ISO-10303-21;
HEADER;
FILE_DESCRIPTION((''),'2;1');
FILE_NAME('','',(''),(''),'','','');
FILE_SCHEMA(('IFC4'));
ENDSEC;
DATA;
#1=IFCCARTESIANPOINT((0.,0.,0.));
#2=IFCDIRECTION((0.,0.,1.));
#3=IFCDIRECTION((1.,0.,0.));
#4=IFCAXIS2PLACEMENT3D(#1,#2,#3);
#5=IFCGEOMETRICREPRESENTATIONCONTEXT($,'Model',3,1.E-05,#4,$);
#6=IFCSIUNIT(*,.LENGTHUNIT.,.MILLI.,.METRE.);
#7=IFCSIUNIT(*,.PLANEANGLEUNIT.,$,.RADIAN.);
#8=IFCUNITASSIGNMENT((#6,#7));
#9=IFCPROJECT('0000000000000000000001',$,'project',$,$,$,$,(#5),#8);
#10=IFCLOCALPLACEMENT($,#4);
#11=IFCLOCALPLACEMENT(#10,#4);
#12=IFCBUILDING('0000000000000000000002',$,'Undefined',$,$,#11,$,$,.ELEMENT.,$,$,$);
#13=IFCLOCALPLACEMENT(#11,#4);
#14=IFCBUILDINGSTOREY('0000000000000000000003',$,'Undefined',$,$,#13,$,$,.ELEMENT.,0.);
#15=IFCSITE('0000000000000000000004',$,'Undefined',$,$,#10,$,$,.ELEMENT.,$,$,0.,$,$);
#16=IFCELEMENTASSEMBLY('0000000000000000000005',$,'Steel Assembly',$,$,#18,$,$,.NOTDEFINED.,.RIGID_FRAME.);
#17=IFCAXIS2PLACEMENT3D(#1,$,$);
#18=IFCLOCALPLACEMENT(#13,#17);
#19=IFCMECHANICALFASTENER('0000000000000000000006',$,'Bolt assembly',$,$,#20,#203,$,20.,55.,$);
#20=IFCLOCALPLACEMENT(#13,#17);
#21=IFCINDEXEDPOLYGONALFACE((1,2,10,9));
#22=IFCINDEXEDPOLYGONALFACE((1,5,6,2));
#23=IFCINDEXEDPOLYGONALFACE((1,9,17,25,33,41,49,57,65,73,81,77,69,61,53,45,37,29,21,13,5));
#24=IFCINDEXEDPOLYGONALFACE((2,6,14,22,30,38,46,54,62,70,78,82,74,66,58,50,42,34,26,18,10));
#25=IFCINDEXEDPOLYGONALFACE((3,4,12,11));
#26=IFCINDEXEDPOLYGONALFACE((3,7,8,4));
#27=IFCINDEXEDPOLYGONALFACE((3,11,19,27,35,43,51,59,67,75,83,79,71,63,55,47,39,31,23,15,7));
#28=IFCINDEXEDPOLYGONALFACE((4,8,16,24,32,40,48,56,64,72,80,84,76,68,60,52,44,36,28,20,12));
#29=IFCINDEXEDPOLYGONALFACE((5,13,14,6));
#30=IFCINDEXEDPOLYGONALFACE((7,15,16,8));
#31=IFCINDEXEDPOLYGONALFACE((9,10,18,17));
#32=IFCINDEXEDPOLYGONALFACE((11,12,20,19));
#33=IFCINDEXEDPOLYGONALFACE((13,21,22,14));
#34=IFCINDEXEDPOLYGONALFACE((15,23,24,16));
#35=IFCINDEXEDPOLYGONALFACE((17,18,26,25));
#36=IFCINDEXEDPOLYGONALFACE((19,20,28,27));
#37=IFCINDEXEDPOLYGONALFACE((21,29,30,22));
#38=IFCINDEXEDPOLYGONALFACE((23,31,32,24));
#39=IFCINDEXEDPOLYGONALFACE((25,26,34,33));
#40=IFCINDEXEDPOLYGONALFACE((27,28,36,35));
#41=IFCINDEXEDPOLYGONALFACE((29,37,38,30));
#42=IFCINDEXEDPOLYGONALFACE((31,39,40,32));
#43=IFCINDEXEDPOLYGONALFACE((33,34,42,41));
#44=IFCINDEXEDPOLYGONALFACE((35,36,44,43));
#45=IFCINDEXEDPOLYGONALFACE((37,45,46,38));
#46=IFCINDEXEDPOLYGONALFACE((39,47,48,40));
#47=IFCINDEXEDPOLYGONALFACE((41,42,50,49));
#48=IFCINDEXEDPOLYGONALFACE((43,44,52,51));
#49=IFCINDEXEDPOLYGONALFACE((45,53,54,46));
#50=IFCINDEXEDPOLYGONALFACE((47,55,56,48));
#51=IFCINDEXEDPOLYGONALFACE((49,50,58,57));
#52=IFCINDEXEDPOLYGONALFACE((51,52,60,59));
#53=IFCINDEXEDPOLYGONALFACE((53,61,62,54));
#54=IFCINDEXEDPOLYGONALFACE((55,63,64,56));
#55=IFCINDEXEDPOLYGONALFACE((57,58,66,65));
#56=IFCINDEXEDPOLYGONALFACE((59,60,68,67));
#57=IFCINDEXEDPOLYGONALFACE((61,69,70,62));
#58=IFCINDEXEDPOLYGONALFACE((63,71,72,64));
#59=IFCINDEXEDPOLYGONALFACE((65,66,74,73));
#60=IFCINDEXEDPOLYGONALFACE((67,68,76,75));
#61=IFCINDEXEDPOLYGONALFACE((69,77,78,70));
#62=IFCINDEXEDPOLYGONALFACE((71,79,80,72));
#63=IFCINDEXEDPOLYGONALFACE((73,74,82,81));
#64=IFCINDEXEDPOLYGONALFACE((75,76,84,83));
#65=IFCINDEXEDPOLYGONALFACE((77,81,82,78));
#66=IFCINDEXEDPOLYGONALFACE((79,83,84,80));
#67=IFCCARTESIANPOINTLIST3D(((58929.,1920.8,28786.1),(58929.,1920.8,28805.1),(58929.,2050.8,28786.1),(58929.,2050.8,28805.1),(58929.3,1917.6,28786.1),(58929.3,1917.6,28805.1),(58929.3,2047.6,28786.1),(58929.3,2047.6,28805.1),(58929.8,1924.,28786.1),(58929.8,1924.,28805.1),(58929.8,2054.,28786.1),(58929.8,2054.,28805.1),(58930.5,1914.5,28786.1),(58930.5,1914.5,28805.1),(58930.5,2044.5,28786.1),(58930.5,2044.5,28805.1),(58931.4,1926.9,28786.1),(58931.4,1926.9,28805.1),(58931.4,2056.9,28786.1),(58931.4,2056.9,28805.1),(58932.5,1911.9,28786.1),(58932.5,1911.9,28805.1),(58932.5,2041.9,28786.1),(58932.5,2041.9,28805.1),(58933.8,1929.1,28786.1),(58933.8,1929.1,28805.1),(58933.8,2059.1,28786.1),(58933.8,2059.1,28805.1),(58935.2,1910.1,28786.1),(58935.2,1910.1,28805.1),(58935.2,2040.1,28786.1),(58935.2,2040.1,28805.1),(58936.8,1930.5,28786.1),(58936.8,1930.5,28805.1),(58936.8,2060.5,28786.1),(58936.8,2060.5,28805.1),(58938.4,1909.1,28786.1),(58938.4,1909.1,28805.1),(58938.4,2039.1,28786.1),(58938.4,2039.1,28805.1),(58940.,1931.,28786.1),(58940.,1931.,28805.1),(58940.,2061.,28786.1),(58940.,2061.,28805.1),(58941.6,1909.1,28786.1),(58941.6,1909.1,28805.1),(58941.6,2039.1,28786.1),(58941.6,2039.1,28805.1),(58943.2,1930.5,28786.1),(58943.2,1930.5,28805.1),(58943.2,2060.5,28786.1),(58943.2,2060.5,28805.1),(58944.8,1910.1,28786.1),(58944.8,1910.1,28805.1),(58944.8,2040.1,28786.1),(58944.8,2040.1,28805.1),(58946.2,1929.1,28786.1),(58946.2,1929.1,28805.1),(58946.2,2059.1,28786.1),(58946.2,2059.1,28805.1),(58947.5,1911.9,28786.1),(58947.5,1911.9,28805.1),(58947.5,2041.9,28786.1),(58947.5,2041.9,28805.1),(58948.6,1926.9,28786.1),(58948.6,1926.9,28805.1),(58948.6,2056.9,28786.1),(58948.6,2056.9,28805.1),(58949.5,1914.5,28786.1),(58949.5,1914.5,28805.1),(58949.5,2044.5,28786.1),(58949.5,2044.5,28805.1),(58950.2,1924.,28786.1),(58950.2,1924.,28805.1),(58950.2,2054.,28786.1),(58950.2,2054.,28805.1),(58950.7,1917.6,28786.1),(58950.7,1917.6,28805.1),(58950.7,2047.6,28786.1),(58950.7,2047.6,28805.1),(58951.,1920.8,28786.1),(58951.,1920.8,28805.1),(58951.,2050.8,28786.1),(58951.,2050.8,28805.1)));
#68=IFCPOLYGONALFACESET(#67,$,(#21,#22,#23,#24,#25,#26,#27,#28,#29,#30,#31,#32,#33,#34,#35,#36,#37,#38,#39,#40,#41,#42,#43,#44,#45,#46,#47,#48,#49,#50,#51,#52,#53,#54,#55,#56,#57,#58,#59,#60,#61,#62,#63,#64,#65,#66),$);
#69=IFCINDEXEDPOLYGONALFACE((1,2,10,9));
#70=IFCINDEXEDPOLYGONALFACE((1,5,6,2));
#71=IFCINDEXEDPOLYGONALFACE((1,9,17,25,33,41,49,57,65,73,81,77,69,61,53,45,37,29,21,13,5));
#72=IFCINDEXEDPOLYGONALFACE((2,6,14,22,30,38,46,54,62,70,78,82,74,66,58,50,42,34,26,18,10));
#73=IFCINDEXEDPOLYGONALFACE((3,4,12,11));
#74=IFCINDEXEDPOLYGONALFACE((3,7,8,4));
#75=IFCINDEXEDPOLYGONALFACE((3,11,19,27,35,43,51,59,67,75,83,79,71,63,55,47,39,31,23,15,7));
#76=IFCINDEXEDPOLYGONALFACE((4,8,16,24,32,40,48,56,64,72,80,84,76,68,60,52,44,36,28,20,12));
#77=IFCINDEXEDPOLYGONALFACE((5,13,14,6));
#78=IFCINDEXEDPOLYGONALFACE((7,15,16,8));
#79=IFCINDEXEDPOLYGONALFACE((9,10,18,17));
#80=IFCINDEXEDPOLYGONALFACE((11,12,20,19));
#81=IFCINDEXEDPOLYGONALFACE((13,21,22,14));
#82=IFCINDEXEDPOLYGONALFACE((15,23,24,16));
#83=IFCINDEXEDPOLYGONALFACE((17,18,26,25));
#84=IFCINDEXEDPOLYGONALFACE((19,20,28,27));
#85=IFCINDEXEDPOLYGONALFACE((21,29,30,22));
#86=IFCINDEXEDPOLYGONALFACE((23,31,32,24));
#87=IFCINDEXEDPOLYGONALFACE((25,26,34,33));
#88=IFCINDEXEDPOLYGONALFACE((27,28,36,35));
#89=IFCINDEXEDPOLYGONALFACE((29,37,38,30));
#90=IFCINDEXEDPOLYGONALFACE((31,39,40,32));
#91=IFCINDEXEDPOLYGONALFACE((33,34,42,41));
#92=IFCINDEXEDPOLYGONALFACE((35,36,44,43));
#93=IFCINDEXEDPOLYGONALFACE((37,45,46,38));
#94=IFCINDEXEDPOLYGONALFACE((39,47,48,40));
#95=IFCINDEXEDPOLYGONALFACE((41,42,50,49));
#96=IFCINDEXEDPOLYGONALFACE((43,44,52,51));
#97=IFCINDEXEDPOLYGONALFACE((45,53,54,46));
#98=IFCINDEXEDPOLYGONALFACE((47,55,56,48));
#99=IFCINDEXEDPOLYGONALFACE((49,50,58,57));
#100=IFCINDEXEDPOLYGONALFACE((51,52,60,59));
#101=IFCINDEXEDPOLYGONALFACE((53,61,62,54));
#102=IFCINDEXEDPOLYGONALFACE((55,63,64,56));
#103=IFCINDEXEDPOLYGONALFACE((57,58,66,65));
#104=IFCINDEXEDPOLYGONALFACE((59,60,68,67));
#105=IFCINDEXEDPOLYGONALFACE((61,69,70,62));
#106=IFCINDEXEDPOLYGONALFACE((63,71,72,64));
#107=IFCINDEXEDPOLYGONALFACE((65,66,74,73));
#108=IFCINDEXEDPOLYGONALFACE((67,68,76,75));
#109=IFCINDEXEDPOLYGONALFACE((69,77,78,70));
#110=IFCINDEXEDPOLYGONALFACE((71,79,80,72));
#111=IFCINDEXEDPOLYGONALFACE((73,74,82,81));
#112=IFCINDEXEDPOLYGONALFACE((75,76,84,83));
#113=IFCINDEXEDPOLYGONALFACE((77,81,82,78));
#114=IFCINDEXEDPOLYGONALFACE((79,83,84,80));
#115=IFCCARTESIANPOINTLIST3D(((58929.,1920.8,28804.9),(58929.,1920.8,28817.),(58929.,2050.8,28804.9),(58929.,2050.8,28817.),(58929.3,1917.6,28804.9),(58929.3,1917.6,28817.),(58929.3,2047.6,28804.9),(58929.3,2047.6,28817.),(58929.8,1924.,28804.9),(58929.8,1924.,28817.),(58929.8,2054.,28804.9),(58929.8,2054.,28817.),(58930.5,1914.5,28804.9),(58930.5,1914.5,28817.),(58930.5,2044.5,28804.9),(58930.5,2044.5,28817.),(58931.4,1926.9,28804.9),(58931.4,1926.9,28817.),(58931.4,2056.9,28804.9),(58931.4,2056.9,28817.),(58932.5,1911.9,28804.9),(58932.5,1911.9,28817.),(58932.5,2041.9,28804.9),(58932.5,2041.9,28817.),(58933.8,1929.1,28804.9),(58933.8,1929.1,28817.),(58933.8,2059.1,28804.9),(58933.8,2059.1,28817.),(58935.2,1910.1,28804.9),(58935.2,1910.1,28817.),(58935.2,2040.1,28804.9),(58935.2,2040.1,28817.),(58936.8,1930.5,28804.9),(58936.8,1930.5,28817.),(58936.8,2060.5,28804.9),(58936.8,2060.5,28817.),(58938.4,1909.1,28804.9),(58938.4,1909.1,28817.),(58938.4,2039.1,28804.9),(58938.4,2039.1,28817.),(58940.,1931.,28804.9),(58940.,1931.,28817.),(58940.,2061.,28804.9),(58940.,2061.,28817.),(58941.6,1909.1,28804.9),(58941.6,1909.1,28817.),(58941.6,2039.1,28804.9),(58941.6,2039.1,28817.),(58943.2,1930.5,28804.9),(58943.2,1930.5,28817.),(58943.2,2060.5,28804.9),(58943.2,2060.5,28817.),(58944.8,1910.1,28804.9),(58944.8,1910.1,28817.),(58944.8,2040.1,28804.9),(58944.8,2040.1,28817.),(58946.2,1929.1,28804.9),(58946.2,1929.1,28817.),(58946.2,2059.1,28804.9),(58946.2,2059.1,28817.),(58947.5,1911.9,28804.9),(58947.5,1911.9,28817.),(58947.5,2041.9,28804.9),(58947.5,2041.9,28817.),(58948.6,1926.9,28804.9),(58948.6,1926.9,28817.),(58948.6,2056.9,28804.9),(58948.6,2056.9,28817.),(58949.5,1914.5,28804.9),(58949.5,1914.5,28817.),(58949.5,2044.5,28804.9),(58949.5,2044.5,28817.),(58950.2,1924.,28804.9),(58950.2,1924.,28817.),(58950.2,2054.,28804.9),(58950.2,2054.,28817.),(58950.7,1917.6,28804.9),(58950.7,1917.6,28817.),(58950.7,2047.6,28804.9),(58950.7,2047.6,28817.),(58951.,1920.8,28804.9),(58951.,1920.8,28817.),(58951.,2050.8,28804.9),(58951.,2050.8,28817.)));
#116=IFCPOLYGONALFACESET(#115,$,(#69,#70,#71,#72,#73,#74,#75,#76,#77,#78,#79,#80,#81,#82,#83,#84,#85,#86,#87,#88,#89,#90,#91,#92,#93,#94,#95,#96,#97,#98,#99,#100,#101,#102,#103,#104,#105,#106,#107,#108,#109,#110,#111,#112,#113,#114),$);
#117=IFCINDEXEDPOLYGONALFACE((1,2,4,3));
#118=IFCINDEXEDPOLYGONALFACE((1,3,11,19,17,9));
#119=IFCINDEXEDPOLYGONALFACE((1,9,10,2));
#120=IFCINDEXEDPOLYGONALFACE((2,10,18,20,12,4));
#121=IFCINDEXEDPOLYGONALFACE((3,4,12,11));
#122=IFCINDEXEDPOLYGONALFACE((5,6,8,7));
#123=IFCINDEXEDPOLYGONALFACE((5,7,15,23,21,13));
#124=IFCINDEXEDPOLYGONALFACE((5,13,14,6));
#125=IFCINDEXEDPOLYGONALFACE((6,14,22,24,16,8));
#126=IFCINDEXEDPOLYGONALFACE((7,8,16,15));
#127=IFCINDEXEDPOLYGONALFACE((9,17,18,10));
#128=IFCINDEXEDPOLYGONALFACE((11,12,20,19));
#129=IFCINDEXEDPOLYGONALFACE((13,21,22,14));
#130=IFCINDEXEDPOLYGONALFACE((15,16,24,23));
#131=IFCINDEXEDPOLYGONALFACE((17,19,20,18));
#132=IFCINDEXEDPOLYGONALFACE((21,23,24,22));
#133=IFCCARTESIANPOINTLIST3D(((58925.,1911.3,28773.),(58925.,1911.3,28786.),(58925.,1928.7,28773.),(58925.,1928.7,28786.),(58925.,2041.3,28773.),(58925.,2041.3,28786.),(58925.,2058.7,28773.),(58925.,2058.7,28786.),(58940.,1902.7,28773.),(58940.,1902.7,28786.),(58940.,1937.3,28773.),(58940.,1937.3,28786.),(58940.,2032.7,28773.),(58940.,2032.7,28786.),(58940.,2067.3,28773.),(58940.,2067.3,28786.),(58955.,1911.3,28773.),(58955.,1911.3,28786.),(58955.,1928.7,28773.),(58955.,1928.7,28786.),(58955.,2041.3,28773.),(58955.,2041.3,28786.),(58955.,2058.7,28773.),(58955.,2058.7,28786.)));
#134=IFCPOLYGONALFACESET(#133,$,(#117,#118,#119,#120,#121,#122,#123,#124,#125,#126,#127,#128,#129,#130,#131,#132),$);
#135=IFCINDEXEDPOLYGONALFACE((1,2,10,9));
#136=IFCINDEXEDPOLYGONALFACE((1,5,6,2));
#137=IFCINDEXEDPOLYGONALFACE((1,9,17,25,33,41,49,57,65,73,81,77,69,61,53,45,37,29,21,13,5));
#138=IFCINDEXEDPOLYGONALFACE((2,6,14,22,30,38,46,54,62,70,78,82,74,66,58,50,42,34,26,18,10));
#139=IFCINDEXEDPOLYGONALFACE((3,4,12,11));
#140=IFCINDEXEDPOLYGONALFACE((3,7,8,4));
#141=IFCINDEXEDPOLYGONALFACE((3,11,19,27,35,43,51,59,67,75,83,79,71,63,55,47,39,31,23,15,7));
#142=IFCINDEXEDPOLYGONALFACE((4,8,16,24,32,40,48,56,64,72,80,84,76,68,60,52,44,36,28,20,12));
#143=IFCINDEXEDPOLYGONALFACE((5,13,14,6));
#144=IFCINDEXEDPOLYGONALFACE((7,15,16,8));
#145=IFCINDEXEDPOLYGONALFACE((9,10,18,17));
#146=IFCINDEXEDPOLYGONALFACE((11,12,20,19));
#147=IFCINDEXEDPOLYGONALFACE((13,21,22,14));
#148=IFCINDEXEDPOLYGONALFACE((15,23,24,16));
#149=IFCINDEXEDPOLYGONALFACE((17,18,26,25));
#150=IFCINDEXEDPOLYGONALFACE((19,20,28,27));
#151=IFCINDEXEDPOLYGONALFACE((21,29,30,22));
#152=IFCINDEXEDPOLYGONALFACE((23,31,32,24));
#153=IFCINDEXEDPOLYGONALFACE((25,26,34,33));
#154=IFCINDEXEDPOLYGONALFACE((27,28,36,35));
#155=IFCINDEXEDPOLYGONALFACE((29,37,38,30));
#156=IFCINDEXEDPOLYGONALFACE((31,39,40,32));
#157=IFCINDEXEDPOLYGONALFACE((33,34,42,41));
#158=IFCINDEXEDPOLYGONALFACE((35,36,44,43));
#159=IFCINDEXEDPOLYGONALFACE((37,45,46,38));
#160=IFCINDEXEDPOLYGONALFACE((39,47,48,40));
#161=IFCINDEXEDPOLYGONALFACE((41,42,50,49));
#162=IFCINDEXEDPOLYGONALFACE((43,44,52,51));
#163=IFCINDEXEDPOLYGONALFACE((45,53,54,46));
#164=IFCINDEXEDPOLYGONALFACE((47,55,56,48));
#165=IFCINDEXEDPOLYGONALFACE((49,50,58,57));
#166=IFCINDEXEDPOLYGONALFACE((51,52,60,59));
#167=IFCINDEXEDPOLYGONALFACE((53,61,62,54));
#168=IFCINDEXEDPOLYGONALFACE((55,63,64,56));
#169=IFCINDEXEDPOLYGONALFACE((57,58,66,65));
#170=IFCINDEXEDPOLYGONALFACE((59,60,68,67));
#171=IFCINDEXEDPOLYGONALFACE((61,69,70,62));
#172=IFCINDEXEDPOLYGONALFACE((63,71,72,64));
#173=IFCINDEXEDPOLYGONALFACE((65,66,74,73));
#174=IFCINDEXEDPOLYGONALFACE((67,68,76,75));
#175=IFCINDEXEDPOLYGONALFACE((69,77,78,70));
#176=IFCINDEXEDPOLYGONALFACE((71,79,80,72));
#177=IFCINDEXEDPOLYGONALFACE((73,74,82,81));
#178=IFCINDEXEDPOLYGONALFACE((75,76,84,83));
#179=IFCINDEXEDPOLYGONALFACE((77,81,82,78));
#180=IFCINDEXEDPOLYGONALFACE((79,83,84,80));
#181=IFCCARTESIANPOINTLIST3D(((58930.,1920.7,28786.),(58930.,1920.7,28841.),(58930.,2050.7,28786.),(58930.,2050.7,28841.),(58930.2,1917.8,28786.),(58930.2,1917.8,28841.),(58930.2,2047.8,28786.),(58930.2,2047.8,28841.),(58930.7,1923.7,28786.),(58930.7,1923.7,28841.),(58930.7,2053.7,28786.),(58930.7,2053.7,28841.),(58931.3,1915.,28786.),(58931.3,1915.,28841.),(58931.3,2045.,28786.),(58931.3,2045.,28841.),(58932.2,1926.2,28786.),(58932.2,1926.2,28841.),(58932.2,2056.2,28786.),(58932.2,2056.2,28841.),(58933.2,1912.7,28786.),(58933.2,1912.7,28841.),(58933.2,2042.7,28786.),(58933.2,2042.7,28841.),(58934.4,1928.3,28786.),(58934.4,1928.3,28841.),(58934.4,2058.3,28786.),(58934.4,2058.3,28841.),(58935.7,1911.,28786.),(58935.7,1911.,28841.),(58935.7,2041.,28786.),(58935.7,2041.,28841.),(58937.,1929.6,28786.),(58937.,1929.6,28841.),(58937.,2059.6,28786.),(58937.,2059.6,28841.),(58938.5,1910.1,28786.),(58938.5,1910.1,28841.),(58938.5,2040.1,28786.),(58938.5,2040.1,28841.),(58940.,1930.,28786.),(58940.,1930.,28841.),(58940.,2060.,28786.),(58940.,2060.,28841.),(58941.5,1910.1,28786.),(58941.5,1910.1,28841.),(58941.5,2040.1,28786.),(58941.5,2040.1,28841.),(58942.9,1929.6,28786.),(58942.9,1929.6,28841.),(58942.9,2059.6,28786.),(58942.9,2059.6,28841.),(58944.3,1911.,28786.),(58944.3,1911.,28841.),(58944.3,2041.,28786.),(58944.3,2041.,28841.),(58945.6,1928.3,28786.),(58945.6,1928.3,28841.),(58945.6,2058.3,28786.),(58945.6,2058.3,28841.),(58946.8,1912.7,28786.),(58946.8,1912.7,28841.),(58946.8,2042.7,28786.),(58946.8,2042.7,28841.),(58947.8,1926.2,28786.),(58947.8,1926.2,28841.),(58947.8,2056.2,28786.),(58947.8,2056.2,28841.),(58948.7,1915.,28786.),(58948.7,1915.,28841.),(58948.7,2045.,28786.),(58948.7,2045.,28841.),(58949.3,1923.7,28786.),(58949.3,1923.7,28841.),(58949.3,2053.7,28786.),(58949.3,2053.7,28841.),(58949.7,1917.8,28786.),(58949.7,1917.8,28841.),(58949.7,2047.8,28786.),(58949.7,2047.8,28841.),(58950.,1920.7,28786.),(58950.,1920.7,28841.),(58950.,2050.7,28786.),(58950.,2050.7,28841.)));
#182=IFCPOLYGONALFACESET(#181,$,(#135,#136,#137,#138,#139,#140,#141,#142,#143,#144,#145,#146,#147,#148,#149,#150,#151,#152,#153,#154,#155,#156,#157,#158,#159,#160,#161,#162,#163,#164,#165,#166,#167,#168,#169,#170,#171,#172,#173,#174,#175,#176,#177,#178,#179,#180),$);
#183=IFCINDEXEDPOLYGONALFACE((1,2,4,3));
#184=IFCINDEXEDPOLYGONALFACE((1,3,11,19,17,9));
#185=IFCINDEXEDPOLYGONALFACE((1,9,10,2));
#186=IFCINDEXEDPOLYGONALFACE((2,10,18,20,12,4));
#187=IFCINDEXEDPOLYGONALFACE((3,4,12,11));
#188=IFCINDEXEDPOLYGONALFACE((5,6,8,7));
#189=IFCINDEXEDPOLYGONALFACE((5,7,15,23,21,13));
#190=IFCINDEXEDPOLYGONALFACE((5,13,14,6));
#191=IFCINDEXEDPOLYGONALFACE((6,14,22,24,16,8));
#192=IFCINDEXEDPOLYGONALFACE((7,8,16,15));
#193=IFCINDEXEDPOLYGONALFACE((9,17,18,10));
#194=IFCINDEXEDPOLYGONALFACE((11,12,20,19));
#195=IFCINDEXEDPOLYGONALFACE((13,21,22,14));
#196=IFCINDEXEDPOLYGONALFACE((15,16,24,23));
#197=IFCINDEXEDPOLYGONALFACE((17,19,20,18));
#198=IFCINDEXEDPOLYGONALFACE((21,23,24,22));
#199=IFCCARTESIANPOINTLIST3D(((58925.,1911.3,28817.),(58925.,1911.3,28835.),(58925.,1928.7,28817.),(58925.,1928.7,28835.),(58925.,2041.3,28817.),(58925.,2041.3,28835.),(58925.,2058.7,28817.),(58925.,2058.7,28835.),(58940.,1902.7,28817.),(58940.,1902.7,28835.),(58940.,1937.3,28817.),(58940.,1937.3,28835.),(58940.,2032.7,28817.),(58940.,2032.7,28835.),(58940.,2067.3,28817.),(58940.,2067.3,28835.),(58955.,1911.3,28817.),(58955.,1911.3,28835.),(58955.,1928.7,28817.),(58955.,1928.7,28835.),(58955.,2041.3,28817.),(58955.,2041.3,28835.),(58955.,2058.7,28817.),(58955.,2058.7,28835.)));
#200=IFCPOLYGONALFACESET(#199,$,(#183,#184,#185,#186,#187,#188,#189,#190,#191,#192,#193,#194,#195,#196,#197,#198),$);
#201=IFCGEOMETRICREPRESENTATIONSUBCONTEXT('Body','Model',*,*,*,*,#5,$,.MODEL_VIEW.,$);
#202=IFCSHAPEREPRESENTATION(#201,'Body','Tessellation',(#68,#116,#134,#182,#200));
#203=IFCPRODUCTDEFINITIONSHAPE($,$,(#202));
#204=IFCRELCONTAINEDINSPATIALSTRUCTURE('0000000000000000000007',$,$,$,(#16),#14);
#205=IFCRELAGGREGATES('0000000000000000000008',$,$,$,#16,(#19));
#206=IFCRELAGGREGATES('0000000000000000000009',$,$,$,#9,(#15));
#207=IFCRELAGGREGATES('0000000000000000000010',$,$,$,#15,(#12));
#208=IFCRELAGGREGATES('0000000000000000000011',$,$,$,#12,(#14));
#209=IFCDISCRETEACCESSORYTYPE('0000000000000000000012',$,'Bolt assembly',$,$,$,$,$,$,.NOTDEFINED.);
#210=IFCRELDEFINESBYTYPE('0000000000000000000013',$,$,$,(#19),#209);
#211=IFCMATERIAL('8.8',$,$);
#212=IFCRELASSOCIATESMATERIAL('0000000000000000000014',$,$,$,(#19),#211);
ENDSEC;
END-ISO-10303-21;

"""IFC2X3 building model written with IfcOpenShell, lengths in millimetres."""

from ifc_helpers import new_model, si_unit, frame, origin_with_axes, origin_2d_with_axis, place, context, subcontext, project, spatial, polyline, circle, outline, extrude, source, transform, mapped, material, type_object, element, aggregate, save


model = new_model("IFC2X3")

# Units and contexts
model_context = context("Model", 3, precision=1e-05, world=origin_with_axes())
body_context = subcontext(model_context, "Body", "Model", "MODEL_VIEW")
ifc_project = project(units=[si_unit("LENGTHUNIT", "METRE", prefix="MILLI"), si_unit("PLANEANGLEUNIT", "RADIAN")], contexts=[model_context])

# Site, building, storey
site_placement = place(None, origin_with_axes())
site = spatial("IfcSite", under=ifc_project, at=site_placement, Name="Undefined", CompositionType="ELEMENT", RefElevation=0.0)
building_placement = place(site_placement, origin_with_axes())
building = spatial("IfcBuilding", under=site, at=building_placement, Name="Undefined", CompositionType="ELEMENT")
storey_placement = place(building_placement, origin_with_axes())
storey = spatial("IfcBuildingStorey", under=building, at=storey_placement, Name="Undefined", CompositionType="ELEMENT", Elevation=0.0)

# Element assembly
assembly_1_placement = place(storey_placement, origin_with_axes())
assembly_1 = element("IfcElementAssembly", 1, at=assembly_1_placement, inside=storey, Name="Steel Assembly", AssemblyPlace="NOTDEFINED", PredefinedType="RIGID_FRAME")

# Mechanical fastener
ifc_material_1 = material(Name="8.8")
discrete_accessory_type_1 = type_object("IfcDiscreteAccessoryType", Name="Bolt assembly")
shared_shape_1 = source(origin_with_axes(), body_context, "Body", "SweptSolid", [
    extrude(circle(Radius=11.0, at=origin_2d_with_axis()), frame((0.0, -18.9, 0.0), z_axis=(0.0, 1.0, 0.0), x_axis=(1.0, 0.0, 0.0)), (0.0, 0.0, 1.0), 19.0),
    extrude(circle(Radius=11.0, at=origin_2d_with_axis()), frame((0.0, -0.1, 0.0), z_axis=(0.0, 1.0, 0.0), x_axis=(1.0, 0.0, 0.0)), (0.0, 0.0, 1.0), 12.1),
    extrude(outline(polyline([(17.3, 0.0), (8.7, 15.0), (-8.7, 15.0), (-17.3, 0.0), (-8.7, -15.0), (8.7, -15.0), (17.3, 0.0)])), frame((0.0, -32.0, 0.0), z_axis=(0.0, 1.0, 0.0), x_axis=(1.0, 0.0, 0.0)), (0.0, 0.0, 1.0), 13.0),
    extrude(circle(Radius=10.0, at=origin_2d_with_axis()), frame((0.0, -19.0, 0.0), z_axis=(0.0, 1.0, 0.0), x_axis=(1.0, 0.0, 0.0)), (0.0, 0.0, 1.0), 55.0),
    extrude(outline(polyline([(17.3, 0.0), (8.7, 15.0), (-8.7, 15.0), (-17.3, 0.0), (-8.7, -15.0), (8.7, -15.0), (17.3, 0.0)])), frame((0.0, 12.0, 0.0), z_axis=(0.0, 1.0, 0.0), x_axis=(1.0, 0.0, 0.0)), (0.0, 0.0, 1.0), 18.0),
])
mechanical_fastener_1_placement = place(assembly_1_placement, frame((58940.0, 1920.0, 28805.0), z_axis=(1.0, 0.0, 0.0), x_axis=(0.0, 1.0, 0.0)))
mechanical_fastener_1 = element("IfcMechanicalFastener", 2, at=mechanical_fastener_1_placement, type_object=discrete_accessory_type_1, material=ifc_material_1, Name="Bolt assembly", NominalDiameter=20.0, NominalLength=55.0, context=body_context, shape_type="MappedRepresentation", body=[
    mapped(shared_shape_1, transform((0.0, 0.0, 0.0))),
    mapped(shared_shape_1, transform((130.0, 0.0, 0.0))),
])

aggregate(assembly_1, [mechanical_fastener_1])

save(model, "model.ifc")
